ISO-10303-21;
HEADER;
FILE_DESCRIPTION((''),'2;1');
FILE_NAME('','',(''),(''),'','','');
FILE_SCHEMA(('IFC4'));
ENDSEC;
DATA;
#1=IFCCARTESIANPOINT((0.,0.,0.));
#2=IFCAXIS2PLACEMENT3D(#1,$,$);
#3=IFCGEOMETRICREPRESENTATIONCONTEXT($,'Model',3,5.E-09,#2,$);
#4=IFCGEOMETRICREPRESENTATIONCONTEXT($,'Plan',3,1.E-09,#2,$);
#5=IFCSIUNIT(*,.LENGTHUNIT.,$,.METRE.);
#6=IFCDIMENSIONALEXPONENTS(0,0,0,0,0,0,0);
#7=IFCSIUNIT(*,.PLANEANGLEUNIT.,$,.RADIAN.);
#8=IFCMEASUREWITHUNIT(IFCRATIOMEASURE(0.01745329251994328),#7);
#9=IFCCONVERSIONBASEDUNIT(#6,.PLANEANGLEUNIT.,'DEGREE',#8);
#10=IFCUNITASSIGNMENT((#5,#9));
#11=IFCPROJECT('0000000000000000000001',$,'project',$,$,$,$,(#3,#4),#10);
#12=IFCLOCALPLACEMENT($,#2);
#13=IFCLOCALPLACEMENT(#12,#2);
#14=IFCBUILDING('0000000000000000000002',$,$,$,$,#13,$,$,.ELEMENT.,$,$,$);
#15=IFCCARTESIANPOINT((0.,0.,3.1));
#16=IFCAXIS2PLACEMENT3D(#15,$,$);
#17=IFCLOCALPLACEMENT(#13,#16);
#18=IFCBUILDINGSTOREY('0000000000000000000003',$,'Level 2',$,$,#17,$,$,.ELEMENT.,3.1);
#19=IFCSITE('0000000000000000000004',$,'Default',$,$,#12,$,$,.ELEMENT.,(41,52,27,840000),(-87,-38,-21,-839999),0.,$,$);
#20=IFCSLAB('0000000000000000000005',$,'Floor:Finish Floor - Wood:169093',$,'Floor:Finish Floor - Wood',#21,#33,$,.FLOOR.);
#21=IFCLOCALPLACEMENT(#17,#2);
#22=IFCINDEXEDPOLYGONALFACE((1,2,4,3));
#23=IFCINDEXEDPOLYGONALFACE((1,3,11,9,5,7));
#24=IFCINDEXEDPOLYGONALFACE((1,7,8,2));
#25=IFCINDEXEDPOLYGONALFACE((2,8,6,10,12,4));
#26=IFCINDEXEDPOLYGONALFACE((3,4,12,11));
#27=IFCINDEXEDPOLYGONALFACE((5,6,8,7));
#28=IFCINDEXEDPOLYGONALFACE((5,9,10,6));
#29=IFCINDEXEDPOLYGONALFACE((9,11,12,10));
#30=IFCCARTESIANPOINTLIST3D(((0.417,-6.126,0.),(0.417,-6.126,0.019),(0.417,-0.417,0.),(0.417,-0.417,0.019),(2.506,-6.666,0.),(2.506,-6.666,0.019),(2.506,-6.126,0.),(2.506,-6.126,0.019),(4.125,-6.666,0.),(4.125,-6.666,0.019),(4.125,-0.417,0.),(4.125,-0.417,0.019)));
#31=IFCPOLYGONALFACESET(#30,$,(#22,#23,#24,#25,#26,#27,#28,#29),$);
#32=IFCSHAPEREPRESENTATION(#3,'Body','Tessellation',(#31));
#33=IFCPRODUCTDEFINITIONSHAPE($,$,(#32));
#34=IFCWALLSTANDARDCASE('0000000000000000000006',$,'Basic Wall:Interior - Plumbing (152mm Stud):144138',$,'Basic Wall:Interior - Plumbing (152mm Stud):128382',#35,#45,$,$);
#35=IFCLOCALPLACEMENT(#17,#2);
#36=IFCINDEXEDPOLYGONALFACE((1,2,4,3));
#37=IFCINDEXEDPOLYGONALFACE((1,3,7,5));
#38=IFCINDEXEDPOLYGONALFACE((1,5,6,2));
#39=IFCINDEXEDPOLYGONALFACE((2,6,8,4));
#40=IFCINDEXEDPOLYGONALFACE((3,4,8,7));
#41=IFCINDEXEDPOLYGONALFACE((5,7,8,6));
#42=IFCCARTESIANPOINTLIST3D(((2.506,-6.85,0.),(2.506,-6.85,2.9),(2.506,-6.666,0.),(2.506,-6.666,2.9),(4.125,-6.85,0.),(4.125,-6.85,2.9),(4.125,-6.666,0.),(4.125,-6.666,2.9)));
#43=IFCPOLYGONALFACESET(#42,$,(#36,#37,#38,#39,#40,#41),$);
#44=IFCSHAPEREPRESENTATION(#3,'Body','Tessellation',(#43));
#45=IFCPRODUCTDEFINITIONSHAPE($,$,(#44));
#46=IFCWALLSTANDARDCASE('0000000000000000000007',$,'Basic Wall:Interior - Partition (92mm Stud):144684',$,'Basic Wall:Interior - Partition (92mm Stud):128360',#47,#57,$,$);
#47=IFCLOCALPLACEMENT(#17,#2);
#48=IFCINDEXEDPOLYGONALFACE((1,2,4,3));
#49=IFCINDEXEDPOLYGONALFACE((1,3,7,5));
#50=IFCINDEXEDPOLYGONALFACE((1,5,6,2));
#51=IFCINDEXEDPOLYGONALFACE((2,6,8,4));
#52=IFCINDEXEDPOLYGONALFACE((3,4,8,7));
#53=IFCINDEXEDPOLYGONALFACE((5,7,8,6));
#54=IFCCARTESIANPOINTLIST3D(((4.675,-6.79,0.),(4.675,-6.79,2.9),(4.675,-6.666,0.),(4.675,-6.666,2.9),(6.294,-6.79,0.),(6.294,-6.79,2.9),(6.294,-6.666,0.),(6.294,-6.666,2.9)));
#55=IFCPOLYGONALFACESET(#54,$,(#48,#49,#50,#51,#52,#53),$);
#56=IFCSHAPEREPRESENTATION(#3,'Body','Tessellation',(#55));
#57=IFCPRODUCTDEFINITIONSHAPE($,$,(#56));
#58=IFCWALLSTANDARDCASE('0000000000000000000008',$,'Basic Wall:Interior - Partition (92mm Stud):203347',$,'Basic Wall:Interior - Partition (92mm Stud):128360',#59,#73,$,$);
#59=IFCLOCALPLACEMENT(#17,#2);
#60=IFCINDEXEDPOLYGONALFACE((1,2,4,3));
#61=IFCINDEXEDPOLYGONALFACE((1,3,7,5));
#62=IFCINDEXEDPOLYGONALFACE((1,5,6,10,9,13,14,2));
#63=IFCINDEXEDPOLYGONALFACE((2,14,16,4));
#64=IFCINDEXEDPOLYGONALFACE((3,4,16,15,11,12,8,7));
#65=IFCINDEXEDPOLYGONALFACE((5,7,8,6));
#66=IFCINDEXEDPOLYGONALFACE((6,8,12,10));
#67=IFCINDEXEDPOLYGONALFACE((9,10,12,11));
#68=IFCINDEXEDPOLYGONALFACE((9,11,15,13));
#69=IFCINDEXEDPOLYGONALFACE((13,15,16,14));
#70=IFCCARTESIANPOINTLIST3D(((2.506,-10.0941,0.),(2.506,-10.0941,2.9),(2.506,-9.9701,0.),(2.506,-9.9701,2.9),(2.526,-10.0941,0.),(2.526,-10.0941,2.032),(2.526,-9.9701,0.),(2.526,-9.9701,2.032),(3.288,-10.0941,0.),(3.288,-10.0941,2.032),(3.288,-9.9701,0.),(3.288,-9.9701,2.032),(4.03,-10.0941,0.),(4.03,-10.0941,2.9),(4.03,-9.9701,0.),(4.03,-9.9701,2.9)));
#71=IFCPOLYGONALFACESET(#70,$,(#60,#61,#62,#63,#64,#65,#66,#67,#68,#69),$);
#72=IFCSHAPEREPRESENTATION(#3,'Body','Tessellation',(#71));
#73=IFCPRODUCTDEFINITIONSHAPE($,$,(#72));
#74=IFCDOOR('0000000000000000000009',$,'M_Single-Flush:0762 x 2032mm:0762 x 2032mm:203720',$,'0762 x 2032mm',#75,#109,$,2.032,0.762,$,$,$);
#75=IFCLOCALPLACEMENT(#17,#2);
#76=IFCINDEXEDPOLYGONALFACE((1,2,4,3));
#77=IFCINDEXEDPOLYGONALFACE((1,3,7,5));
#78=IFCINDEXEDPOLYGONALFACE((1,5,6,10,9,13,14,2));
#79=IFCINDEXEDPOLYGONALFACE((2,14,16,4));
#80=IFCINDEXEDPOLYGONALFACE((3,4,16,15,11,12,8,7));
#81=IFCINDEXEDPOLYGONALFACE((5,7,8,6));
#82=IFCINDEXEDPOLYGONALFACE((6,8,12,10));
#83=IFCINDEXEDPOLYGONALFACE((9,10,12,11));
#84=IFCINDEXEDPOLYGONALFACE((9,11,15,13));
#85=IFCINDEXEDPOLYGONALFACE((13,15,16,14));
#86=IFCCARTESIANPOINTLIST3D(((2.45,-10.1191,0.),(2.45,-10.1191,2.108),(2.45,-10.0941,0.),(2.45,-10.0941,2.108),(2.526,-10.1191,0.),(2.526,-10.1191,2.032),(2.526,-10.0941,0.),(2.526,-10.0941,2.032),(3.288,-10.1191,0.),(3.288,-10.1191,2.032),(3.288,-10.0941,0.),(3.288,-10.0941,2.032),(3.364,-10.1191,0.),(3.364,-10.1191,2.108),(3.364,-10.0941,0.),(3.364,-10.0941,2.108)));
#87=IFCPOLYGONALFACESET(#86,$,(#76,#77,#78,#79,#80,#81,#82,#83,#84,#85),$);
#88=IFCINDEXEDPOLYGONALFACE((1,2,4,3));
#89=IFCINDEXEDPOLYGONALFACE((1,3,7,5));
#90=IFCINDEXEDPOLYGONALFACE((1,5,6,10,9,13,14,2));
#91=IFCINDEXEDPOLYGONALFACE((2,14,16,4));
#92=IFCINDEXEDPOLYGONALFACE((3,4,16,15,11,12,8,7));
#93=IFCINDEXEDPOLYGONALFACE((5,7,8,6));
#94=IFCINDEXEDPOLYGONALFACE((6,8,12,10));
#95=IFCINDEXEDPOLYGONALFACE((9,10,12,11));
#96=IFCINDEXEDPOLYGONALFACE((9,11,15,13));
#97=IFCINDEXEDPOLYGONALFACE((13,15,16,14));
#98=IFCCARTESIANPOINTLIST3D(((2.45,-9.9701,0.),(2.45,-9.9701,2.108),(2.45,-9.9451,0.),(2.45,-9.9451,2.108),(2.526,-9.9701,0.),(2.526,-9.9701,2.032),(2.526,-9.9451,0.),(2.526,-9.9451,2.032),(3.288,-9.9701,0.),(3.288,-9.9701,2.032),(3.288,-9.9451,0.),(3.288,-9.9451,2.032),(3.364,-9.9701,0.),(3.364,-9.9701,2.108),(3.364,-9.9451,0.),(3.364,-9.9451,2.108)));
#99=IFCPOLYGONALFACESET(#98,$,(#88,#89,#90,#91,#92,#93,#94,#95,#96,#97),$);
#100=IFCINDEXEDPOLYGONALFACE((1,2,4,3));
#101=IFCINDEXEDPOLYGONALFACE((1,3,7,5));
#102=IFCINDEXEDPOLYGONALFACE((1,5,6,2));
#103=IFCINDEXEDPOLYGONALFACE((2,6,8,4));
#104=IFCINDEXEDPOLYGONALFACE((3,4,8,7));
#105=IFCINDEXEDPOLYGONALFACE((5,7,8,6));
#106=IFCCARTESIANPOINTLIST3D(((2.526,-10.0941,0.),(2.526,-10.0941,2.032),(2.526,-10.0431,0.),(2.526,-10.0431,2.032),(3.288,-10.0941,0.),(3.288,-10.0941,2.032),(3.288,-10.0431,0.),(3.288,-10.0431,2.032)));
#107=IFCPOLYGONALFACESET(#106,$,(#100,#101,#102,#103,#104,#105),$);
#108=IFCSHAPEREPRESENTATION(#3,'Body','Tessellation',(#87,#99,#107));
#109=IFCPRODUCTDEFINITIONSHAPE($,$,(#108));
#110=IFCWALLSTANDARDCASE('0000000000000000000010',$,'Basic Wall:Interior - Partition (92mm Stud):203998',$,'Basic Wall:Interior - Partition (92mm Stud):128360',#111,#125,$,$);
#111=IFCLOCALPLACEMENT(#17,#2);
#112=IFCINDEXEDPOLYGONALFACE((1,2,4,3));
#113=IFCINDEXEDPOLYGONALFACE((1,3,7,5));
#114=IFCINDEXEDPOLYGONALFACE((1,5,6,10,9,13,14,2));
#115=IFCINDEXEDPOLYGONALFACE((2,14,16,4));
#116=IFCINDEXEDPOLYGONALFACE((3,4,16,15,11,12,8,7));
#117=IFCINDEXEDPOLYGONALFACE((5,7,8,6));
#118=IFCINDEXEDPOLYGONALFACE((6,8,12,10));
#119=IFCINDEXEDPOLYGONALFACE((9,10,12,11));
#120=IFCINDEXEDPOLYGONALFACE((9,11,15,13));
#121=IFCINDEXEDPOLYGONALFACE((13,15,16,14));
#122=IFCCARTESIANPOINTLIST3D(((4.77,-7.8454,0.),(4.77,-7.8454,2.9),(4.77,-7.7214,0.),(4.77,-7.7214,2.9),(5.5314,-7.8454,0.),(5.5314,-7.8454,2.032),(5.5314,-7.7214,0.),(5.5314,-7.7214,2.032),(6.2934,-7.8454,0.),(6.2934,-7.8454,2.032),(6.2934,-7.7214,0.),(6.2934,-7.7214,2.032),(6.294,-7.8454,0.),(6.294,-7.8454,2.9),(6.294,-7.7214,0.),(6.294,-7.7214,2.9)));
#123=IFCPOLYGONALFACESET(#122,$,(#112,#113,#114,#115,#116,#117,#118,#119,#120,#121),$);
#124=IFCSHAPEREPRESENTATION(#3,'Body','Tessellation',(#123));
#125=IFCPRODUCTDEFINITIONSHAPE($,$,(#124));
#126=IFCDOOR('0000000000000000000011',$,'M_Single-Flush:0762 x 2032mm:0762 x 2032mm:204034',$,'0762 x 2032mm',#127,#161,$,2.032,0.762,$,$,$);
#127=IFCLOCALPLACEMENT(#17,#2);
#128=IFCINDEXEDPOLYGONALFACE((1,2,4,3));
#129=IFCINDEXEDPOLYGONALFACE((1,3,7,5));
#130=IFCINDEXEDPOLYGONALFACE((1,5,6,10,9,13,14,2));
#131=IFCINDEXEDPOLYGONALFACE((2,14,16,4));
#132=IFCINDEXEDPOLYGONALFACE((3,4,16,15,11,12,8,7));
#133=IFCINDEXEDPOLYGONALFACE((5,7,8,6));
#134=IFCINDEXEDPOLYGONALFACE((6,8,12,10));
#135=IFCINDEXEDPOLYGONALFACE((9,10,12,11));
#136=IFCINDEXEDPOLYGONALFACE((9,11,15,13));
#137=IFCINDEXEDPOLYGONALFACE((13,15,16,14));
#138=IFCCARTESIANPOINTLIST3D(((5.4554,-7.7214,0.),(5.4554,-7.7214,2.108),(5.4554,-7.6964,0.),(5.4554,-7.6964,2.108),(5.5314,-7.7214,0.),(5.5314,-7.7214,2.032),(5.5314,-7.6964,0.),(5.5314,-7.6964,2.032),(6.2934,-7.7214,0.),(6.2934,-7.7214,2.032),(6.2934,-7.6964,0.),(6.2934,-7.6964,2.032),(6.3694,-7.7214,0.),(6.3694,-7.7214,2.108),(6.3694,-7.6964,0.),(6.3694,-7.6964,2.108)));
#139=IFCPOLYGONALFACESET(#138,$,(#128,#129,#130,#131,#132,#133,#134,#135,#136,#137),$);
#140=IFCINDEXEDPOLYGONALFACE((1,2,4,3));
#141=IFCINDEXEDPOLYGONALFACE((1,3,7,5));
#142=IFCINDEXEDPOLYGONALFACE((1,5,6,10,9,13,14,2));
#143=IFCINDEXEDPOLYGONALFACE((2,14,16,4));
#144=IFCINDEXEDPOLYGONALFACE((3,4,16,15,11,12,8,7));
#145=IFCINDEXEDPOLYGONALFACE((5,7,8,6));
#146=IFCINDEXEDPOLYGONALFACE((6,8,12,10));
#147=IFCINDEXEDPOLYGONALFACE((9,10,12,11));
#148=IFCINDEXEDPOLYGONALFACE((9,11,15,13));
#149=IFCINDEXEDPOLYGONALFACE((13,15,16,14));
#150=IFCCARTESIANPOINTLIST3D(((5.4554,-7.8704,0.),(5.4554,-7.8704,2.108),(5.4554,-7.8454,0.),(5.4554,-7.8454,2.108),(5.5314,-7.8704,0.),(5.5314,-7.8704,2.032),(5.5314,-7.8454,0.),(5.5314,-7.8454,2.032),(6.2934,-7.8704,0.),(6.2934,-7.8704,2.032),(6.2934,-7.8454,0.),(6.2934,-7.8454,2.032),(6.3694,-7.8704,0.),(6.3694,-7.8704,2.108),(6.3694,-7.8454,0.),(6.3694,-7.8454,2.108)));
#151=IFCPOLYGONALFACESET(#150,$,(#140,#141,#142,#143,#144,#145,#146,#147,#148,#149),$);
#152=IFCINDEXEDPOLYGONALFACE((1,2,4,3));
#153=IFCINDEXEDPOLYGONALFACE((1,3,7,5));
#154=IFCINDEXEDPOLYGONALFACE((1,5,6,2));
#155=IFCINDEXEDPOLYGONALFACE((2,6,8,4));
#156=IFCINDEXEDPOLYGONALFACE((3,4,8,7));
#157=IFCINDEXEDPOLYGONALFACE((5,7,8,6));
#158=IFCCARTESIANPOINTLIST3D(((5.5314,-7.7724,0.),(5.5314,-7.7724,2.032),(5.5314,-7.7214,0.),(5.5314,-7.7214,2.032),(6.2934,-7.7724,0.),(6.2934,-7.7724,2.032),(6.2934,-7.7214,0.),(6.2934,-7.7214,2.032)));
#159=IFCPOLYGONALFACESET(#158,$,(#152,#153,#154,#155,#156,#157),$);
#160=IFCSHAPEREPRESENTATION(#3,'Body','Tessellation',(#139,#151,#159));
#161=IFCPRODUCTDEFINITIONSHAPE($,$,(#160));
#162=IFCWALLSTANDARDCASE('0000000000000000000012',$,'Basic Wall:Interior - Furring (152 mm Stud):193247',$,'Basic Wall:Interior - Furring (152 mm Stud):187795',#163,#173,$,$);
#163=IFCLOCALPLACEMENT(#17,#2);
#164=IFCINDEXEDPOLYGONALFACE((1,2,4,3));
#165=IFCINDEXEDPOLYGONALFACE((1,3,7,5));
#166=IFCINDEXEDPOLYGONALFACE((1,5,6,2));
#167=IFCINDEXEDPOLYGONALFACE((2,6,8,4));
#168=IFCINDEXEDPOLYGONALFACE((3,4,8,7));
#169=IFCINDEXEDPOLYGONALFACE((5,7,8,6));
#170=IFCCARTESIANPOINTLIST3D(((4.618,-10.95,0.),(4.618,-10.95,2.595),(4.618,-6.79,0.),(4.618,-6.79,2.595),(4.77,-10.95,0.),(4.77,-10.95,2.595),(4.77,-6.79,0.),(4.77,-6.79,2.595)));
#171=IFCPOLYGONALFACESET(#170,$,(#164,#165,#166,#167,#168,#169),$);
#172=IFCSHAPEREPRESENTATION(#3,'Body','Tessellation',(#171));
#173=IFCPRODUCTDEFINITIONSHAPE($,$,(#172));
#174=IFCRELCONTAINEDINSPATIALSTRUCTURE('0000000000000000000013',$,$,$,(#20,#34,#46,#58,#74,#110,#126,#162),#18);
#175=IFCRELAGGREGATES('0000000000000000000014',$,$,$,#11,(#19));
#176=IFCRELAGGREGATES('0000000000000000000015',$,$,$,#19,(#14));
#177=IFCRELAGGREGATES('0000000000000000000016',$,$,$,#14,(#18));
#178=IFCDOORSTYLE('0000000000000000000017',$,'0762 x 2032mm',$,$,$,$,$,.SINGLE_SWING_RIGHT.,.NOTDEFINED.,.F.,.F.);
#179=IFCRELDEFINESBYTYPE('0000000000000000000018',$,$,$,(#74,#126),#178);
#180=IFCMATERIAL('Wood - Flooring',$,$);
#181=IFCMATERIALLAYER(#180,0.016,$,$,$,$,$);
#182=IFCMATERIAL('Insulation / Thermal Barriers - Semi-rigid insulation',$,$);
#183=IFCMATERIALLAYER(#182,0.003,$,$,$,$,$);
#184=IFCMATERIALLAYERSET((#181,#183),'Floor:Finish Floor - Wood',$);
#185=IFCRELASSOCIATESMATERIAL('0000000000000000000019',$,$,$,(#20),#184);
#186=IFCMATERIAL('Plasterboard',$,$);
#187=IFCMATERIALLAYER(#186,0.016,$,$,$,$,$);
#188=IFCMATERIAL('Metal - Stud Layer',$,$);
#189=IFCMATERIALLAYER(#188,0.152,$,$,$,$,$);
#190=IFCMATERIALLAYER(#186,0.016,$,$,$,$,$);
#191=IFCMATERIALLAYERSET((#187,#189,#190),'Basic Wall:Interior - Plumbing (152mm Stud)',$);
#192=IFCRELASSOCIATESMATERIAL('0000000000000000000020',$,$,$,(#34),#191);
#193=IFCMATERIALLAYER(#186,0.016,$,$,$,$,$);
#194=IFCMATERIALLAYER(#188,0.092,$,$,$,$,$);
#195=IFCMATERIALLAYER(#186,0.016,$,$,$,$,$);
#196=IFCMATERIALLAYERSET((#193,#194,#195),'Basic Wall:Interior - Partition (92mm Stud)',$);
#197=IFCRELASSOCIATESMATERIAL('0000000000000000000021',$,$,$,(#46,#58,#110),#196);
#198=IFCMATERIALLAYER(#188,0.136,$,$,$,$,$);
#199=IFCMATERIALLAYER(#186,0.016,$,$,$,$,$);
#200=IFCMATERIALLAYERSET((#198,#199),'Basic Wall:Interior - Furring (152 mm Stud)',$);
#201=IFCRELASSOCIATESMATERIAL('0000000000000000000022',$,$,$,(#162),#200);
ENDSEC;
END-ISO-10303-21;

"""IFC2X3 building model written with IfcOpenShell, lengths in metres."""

from ifc_helpers import new_model, entity, si_unit, converted_unit, frame, frame_2d, origin, origin_2d_with_axis, place, context, project, spatial, polyline, rectangle, outline, extrude, source, transform, mapped, material, layer, layer_set, layer_usage, type_object, type_shapes, element, fill, save


model = new_model("IFC2X3")

# Units and contexts
model_context = context("Model", 3, precision=5e-09, world=origin())
plan_context = context("Plan", 3, precision=1e-09, world=origin())
ifc_project = project(units=[si_unit("LENGTHUNIT", "METRE"), converted_unit("PLANEANGLEUNIT", "DEGREE", entity("IfcRatioMeasure", 0.01745329251994328), si_unit("PLANEANGLEUNIT", "RADIAN"), dimensions=[0, 0, 0, 0, 0, 0, 0])], contexts=[model_context, plan_context])

# Site, building, storey
site_placement = place(None, origin())
site = spatial("IfcSite", under=ifc_project, at=site_placement, Name="Default", CompositionType="ELEMENT", RefLatitude=(41, 52, 27, 840000), RefLongitude=(-87, -38, -21, -839999), RefElevation=0.0)
building_placement = place(site_placement, origin())
building = spatial("IfcBuilding", under=site, at=building_placement, CompositionType="ELEMENT")
storey_placement = place(building_placement, frame((0.0, 0.0, 3.1)))
storey = spatial("IfcBuildingStorey", under=building, at=storey_placement, Name="Level 2", CompositionType="ELEMENT", Elevation=3.1)

# Slab
ifc_material_1 = material(Name="Wood - Flooring")
ifc_layer_1 = layer(ifc_material_1, 0.016)
ifc_material_2 = material(Name="Insulation / Thermal Barriers - Semi-rigid insulation")
ifc_layer_2 = layer(ifc_material_2, 0.003)
ifc_layer_set_1 = layer_set([ifc_layer_1, ifc_layer_2], Name="Floor:Finish Floor - Wood")
ifc_layer_usage_1 = layer_usage(ifc_layer_set_1, "AXIS3", "POSITIVE", 0.0)
slab_placement = place(storey_placement, frame((0.417, -6.666, 0.0)))
element("IfcSlab", 1, at=slab_placement, inside=storey, material=ifc_layer_usage_1, Name="Floor:Finish Floor - Wood:169093", ObjectType="Floor:Finish Floor - Wood", PredefinedType="FLOOR", context=model_context, shape_type="SweptSolid", body=[
    extrude(outline(polyline([(1.854, 3.1245), (-1.854, 3.1245), (-1.854, -3.1245), (-0.235, -3.1245), (-0.235, -2.5845), (1.854, -2.5845), (1.854, 3.1245)])), frame((1.854, 3.1245, 0.019), z_axis=(0.0, 0.0, -1.0), x_axis=(-1.0, 0.0, 0.0)), (0.0, 0.0, 1.0), 0.019),
])

# Walls
ifc_material_3 = material(Name="Plasterboard")
ifc_layer_3 = layer(ifc_material_3, 0.016)
ifc_material_4 = material(Name="Metal - Stud Layer")
ifc_layer_4 = layer(ifc_material_4, 0.152)
ifc_layer_5 = layer(ifc_material_3, 0.016)
ifc_layer_set_2 = layer_set([ifc_layer_3, ifc_layer_4, ifc_layer_5], Name="Basic Wall:Interior - Plumbing (152mm Stud)")
ifc_layer_usage_2 = layer_usage(ifc_layer_set_2, "AXIS2", "NEGATIVE", 0.092)
wall_1_placement = place(storey_placement, frame((2.506, -6.758, 0.0)))
element("IfcWallStandardCase", 2, at=wall_1_placement, inside=storey, material=ifc_layer_usage_2, Name="Basic Wall:Interior - Plumbing (152mm Stud):144138", ObjectType="Basic Wall:Interior - Plumbing (152mm Stud):128382", context=model_context, shape_type="SweptSolid", body=[
    extrude(rectangle(XDim=1.619, YDim=0.184, at=frame_2d((0.8095, 0.0), x_axis=(-1.0, 0.0))), origin(), (0.0, 0.0, 1.0), 2.9),
])
ifc_layer_6 = layer(ifc_material_3, 0.016)
ifc_layer_7 = layer(ifc_material_4, 0.092)
ifc_layer_8 = layer(ifc_material_3, 0.016)
ifc_layer_set_3 = layer_set([ifc_layer_6, ifc_layer_7, ifc_layer_8], Name="Basic Wall:Interior - Partition (92mm Stud)")
ifc_layer_usage_3 = layer_usage(ifc_layer_set_3, "AXIS2", "NEGATIVE", 0.062)
wall_2_placement = place(storey_placement, frame((4.675, -6.728, 0.0)))
element("IfcWallStandardCase", 3, at=wall_2_placement, inside=storey, material=ifc_layer_usage_3, Name="Basic Wall:Interior - Partition (92mm Stud):144684", ObjectType="Basic Wall:Interior - Partition (92mm Stud):128360", context=model_context, shape_type="SweptSolid", body=[
    extrude(rectangle(XDim=1.619, YDim=0.124, at=frame_2d((0.8095, 0.0), x_axis=(-1.0, 0.0))), origin(), (0.0, 0.0, 1.0), 2.9),
])

# Walls, openings, doors
wall_3_placement = place(storey_placement, frame((4.03, -10.0321, 0.0), z_axis=(0.0, 0.0, 1.0), x_axis=(-1.0, 0.0, 0.0)))
wall_3 = element("IfcWallStandardCase", 4, at=wall_3_placement, inside=storey, material=ifc_layer_usage_3, Name="Basic Wall:Interior - Partition (92mm Stud):203347", ObjectType="Basic Wall:Interior - Partition (92mm Stud):128360", context=model_context, shape_type="SweptSolid", body=[
    extrude(rectangle(XDim=1.524, YDim=0.124, at=frame_2d((0.762, 0.0), x_axis=(-1.0, 0.0))), origin(), (0.0, 0.0, 1.0), 2.9),
])
opening_1_placement = place(wall_3_placement, frame((0.742, -0.062, 0.0)))
opening_1 = element("IfcOpeningElement", 5, at=opening_1_placement, cuts=wall_3, ObjectType="Opening", context=model_context, shape_type="SweptSolid", body=[
    extrude(rectangle(XDim=0.762, YDim=2.032, at=frame_2d((1.016, 0.381), x_axis=(0.0, 1.0))), frame((0.0, 0.0, 0.0), z_axis=(0.0, 1.0, 0.0), x_axis=(0.0, 0.0, 1.0)), (0.0, 0.0, 1.0), 0.124),
])
door_style = type_object("IfcDoorStyle", Name="0762 x 2032mm", ConstructionType="NOTDEFINED", OperationType="SINGLE_SWING_RIGHT", ParameterTakesPrecedence=False, Sizeable=False)
shared_shape = source(origin(), model_context, "Body", "SweptSolid", [
    extrude(outline(polyline([(-0.457, -1.073), (0.457, -1.073), (0.457, 1.035), (0.381, 1.035), (0.381, -0.997), (-0.381, -0.997), (-0.381, 1.035), (-0.457, 1.035), (-0.457, -1.073)])), frame((0.381, 0.124, 1.035), z_axis=(0.0, 1.0, 0.0), x_axis=(1.0, 0.0, 0.0)), (0.0, 0.0, 1.0), 0.025),
    extrude(outline(polyline([(-1.073, -0.457), (1.035, -0.457), (1.035, -0.381), (-0.997, -0.381), (-0.997, 0.381), (1.035, 0.381), (1.035, 0.457), (-1.073, 0.457), (-1.073, -0.457)])), frame((0.381, -0.025, 1.035), z_axis=(0.0, 1.0, 0.0), x_axis=(0.0, 0.0, -1.0)), (0.0, 0.0, 1.0), 0.025),
    extrude(rectangle(XDim=0.051, YDim=0.762, at=origin_2d_with_axis()), frame((0.381, 0.0985, 0.0), z_axis=(0.0, 0.0, 1.0), x_axis=(0.0, 1.0, 0.0)), (0.0, 0.0, 1.0), 2.032),
])
type_shapes(door_style, [shared_shape])
door_1_placement = place(opening_1_placement, origin())
door_1 = element("IfcDoor", 6, at=door_1_placement, inside=storey, type_object=door_style, Name="M_Single-Flush:0762 x 2032mm:0762 x 2032mm:203720", ObjectType="0762 x 2032mm", OverallHeight=2.032, OverallWidth=0.762, context=model_context, shape_type="MappedRepresentation", body=[
    mapped(shared_shape, transform((0.0, 0.0, 0.0), scale=1.0)),
])
fill(opening_1, door_1)
ifc_layer_usage_4 = layer_usage(ifc_layer_set_3, "AXIS2", "POSITIVE", -0.062)
wall_4_placement = place(storey_placement, frame((4.77, -7.7834, 0.0)))
wall_4 = element("IfcWallStandardCase", 7, at=wall_4_placement, inside=storey, material=ifc_layer_usage_4, Name="Basic Wall:Interior - Partition (92mm Stud):203998", ObjectType="Basic Wall:Interior - Partition (92mm Stud):128360", context=model_context, shape_type="SweptSolid", body=[
    extrude(rectangle(XDim=1.524, YDim=0.124, at=frame_2d((0.762, 0.0), x_axis=(-1.0, 0.0))), origin(), (0.0, 0.0, 1.0), 2.9),
])
opening_2_placement = place(wall_4_placement, frame((0.7614, -0.062, 0.0)))
opening_2 = element("IfcOpeningElement", 8, at=opening_2_placement, cuts=wall_4, ObjectType="Opening", context=model_context, shape_type="SweptSolid", body=[
    extrude(rectangle(XDim=0.762, YDim=2.032, at=frame_2d((1.016, 0.381), x_axis=(0.0, 1.0))), frame((0.0, 0.0, 0.0), z_axis=(0.0, 1.0, 0.0), x_axis=(0.0, 0.0, 1.0)), (0.0, 0.0, 1.0), 0.124),
])
door_2_placement = place(opening_2_placement, origin())
door_2 = element("IfcDoor", 9, at=door_2_placement, inside=storey, type_object=door_style, Name="M_Single-Flush:0762 x 2032mm:0762 x 2032mm:204034", ObjectType="0762 x 2032mm", OverallHeight=2.032, OverallWidth=0.762, context=model_context, shape_type="MappedRepresentation", body=[
    mapped(shared_shape, transform((0.0, 0.0, 0.0), scale=1.0)),
])
fill(opening_2, door_2)

# Wall
ifc_layer_9 = layer(ifc_material_4, 0.136)
ifc_layer_10 = layer(ifc_material_3, 0.016)
ifc_layer_set_4 = layer_set([ifc_layer_9, ifc_layer_10], Name="Basic Wall:Interior - Furring (152 mm Stud)")
ifc_layer_usage_5 = layer_usage(ifc_layer_set_4, "AXIS2", "POSITIVE", -0.076)
wall_5_placement = place(storey_placement, frame((4.694, -6.79, 0.0), z_axis=(0.0, 0.0, 1.0), x_axis=(0.0, -1.0, 0.0)))
element("IfcWallStandardCase", 10, at=wall_5_placement, inside=storey, material=ifc_layer_usage_5, Name="Basic Wall:Interior - Furring (152 mm Stud):193247", ObjectType="Basic Wall:Interior - Furring (152 mm Stud):187795", context=model_context, shape_type="SweptSolid", body=[
    extrude(rectangle(XDim=4.16, YDim=0.152, at=frame_2d((2.08, 0.0), x_axis=(-1.0, 0.0))), origin(), (0.0, 0.0, 1.0), 2.595),
])

save(model, "model.ifc")
